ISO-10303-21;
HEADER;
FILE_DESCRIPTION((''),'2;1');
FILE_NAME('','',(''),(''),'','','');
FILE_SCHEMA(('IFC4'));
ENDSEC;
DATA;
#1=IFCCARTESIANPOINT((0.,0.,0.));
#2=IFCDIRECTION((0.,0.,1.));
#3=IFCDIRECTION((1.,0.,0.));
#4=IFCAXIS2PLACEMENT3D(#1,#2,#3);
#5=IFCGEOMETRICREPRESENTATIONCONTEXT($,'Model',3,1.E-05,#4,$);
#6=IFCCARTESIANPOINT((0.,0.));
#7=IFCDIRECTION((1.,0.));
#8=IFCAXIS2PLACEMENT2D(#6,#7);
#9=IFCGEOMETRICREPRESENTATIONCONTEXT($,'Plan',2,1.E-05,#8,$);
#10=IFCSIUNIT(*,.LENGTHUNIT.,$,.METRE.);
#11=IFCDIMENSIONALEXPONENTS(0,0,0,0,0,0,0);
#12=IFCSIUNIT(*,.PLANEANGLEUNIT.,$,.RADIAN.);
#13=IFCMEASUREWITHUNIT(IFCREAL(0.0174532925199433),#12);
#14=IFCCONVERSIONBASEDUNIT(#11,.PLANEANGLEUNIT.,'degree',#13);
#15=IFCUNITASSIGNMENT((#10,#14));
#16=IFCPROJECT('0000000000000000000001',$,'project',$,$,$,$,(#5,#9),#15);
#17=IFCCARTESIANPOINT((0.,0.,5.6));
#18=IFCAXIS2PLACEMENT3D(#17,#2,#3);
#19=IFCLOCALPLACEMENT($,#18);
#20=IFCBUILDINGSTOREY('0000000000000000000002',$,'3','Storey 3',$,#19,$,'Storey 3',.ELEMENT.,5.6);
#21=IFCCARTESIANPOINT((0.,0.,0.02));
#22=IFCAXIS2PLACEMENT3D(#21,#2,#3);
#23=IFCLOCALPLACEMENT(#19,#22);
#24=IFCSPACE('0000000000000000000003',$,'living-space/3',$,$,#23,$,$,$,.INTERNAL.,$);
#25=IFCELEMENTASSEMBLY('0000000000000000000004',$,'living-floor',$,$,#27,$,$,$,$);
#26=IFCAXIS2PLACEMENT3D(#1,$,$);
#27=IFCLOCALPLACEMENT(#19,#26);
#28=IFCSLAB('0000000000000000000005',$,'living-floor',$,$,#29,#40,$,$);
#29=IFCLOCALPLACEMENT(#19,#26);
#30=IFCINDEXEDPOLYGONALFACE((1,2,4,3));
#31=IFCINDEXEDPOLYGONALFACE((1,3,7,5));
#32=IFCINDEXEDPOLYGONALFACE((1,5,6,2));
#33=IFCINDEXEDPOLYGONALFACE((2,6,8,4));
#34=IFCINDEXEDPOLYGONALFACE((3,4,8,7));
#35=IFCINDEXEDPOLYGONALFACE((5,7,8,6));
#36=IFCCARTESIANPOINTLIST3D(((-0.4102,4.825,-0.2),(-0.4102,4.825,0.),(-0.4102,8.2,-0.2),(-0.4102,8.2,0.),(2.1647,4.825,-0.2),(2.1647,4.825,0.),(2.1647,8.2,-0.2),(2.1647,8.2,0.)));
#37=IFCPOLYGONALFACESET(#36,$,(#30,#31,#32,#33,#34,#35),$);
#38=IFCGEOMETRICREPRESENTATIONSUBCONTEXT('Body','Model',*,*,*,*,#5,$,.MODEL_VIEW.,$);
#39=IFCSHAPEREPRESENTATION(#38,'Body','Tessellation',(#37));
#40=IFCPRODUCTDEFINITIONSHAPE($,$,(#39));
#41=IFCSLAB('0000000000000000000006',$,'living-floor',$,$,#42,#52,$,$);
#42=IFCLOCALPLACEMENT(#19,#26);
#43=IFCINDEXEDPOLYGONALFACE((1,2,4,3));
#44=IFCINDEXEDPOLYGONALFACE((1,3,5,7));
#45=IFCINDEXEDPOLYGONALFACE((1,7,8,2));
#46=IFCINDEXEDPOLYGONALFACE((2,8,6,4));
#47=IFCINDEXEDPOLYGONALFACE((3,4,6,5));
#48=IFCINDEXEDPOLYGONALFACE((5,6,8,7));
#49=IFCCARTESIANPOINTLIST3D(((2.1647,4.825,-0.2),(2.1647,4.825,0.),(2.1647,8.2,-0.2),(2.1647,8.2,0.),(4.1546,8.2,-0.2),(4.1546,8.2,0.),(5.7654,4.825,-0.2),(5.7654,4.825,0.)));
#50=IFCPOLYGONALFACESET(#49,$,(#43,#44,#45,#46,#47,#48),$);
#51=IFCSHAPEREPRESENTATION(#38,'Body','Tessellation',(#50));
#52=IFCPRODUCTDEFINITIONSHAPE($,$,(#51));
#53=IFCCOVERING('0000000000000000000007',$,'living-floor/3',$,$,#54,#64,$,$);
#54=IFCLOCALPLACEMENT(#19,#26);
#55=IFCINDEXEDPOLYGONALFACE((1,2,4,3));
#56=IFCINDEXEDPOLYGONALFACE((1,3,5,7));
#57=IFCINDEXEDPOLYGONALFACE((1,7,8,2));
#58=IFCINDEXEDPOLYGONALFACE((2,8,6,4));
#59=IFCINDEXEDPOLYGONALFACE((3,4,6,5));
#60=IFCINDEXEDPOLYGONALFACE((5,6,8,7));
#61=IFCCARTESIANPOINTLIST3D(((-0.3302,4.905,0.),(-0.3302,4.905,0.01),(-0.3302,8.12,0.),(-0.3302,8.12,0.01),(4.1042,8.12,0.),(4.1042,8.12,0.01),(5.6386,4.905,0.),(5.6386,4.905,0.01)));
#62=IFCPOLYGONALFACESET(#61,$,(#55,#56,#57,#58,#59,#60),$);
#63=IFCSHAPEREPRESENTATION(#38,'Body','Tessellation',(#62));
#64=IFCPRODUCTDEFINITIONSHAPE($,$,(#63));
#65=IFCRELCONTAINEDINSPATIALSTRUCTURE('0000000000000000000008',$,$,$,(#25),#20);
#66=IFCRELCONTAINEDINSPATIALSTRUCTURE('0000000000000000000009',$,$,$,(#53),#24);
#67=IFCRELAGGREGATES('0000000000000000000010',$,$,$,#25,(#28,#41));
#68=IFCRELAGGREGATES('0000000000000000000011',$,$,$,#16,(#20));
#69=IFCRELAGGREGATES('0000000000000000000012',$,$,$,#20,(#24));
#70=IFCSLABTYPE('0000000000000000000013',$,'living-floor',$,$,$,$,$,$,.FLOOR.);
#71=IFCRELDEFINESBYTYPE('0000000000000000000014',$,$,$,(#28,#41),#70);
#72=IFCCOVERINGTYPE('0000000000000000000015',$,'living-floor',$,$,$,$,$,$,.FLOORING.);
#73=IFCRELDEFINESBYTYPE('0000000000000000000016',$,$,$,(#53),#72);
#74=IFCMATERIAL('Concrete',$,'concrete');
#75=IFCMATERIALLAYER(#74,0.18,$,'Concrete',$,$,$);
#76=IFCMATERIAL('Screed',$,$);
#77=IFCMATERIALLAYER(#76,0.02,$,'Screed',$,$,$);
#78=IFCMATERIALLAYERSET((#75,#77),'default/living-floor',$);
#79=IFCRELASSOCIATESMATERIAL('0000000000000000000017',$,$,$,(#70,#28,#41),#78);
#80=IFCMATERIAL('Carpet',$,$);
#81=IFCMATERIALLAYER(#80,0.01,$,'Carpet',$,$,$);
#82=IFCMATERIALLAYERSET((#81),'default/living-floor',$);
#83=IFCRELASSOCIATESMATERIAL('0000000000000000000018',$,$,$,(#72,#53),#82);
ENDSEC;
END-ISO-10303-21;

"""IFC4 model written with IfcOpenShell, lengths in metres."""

from ifc_helpers import new_model, entity, si_unit, converted_unit, frame, origin, origin_with_axes, origin_2d_with_axis, place, context, subcontext, project, spatial, polyline, outline, extrude, material, layer, layer_set, layer_usage, type_object, element, aggregate, save


model = new_model("IFC4")

# Units and contexts
model_context = context("Model", 3, precision=1e-05, world=origin_with_axes())
plan_context = context("Plan", 2, precision=1e-05, world=origin_2d_with_axis())
body_context = subcontext(model_context, "Body", "Model", "MODEL_VIEW")
ifc_project = project(units=[si_unit("LENGTHUNIT", "METRE"), converted_unit("PLANEANGLEUNIT", "degree", entity("IfcReal", 0.0174532925199433), si_unit("PLANEANGLEUNIT", "RADIAN"), dimensions=[0, 0, 0, 0, 0, 0, 0])], contexts=[model_context, plan_context])

# Storey
storey_placement = place(None, frame((0.0, 0.0, 5.6), z_axis=(0.0, 0.0, 1.0), x_axis=(1.0, 0.0, 0.0)))
storey = spatial("IfcBuildingStorey", under=ifc_project, at=storey_placement, Name="3", Description="Storey 3", LongName="Storey 3", CompositionType="ELEMENT", Elevation=5.6)

# Element assembly, slabs
assembly_placement = place(storey_placement, frame((0.0, 0.0, -5.6), z_axis=(0.0, 0.0, 1.0), x_axis=(1.0, 0.0, 0.0)))
assembly = element("IfcElementAssembly", 1, at=assembly_placement, inside=storey, Name="living-floor")
ifc_material_1 = material(Name="Concrete", Category="concrete")
ifc_layer_1 = layer(ifc_material_1, 0.18, Name="Concrete")
ifc_material_2 = material(Name="Screed")
ifc_layer_2 = layer(ifc_material_2, 0.02, Name="Screed")
ifc_layer_set_1 = layer_set([ifc_layer_1, ifc_layer_2], Name="default/living-floor")
ifc_layer_usage_1 = layer_usage(ifc_layer_set_1, "AXIS3", "POSITIVE", 0.0)
slab_type = type_object("IfcSlabType", Name="living-floor", PredefinedType="FLOOR", material=ifc_layer_set_1)
slab_1_placement = place(assembly_placement, frame((2.1647, 8.2, 5.4), z_axis=(0.0, 0.0, 1.0), x_axis=(1.0, 0.0, 0.0)))
slab_1 = element("IfcSlab", 2, at=slab_1_placement, type_object=slab_type, material=ifc_layer_usage_1, Name="living-floor", context=body_context, shape_type="SweptSolid", body=[
    extrude(outline(polyline([(0.0, 0.0), (0.0, -3.375), (-2.5749, -3.375), (-2.5749, 0.0), (0.0, 0.0)])), origin(), (0.0, 0.0, 1.0), 0.2),
])
ifc_layer_usage_2 = layer_usage(ifc_layer_set_1, "AXIS3", "POSITIVE", 0.0)
slab_2_placement = place(assembly_placement, frame((2.1647, 8.2, 5.4), z_axis=(0.0, 0.0, 1.0), x_axis=(1.0, 0.0, 0.0)))
slab_2 = element("IfcSlab", 3, at=slab_2_placement, type_object=slab_type, material=ifc_layer_usage_2, Name="living-floor", context=body_context, shape_type="SweptSolid", body=[
    extrude(outline(polyline([(0.0, 0.0), (1.99, 0.0), (3.6007, -3.375), (0.0, -3.375), (0.0, 0.0)])), origin(), (0.0, 0.0, 1.0), 0.2),
])
aggregate(assembly, [slab_1, slab_2])

# Shared definitions
space_placement = place(storey_placement, frame((0.0, 0.0, 0.02), z_axis=(0.0, 0.0, 1.0), x_axis=(1.0, 0.0, 0.0)))
space = spatial("IfcSpace", under=storey, at=space_placement, Name="living-space/3", PredefinedType="INTERNAL")

# Covering
ifc_material_3 = material(Name="Carpet")
ifc_layer_3 = layer(ifc_material_3, 0.01, Name="Carpet")
ifc_layer_set_2 = layer_set([ifc_layer_3], Name="default/living-floor")
ifc_layer_usage_3 = layer_usage(ifc_layer_set_2, "AXIS2", "POSITIVE", 0.0)
covering_type = type_object("IfcCoveringType", Name="living-floor", PredefinedType="FLOORING", material=ifc_layer_set_2)
covering_placement = place(space_placement, frame((0.0, 0.0, -0.02), z_axis=(0.0, 0.0, 1.0), x_axis=(1.0, 0.0, 0.0)))
element("IfcCovering", 4, at=covering_placement, inside=space, type_object=covering_type, material=ifc_layer_usage_3, Name="living-floor/3", context=body_context, shape_type="SweptSolid", body=[
    extrude(outline(polyline([(5.6386, 4.905), (4.1042, 8.12), (-0.3302, 8.12), (-0.3302, 4.905), (5.6386, 4.905)])), origin_with_axes(), (0.0, 0.0, 1.0), 0.01),
])

save(model, "model.ifc")
